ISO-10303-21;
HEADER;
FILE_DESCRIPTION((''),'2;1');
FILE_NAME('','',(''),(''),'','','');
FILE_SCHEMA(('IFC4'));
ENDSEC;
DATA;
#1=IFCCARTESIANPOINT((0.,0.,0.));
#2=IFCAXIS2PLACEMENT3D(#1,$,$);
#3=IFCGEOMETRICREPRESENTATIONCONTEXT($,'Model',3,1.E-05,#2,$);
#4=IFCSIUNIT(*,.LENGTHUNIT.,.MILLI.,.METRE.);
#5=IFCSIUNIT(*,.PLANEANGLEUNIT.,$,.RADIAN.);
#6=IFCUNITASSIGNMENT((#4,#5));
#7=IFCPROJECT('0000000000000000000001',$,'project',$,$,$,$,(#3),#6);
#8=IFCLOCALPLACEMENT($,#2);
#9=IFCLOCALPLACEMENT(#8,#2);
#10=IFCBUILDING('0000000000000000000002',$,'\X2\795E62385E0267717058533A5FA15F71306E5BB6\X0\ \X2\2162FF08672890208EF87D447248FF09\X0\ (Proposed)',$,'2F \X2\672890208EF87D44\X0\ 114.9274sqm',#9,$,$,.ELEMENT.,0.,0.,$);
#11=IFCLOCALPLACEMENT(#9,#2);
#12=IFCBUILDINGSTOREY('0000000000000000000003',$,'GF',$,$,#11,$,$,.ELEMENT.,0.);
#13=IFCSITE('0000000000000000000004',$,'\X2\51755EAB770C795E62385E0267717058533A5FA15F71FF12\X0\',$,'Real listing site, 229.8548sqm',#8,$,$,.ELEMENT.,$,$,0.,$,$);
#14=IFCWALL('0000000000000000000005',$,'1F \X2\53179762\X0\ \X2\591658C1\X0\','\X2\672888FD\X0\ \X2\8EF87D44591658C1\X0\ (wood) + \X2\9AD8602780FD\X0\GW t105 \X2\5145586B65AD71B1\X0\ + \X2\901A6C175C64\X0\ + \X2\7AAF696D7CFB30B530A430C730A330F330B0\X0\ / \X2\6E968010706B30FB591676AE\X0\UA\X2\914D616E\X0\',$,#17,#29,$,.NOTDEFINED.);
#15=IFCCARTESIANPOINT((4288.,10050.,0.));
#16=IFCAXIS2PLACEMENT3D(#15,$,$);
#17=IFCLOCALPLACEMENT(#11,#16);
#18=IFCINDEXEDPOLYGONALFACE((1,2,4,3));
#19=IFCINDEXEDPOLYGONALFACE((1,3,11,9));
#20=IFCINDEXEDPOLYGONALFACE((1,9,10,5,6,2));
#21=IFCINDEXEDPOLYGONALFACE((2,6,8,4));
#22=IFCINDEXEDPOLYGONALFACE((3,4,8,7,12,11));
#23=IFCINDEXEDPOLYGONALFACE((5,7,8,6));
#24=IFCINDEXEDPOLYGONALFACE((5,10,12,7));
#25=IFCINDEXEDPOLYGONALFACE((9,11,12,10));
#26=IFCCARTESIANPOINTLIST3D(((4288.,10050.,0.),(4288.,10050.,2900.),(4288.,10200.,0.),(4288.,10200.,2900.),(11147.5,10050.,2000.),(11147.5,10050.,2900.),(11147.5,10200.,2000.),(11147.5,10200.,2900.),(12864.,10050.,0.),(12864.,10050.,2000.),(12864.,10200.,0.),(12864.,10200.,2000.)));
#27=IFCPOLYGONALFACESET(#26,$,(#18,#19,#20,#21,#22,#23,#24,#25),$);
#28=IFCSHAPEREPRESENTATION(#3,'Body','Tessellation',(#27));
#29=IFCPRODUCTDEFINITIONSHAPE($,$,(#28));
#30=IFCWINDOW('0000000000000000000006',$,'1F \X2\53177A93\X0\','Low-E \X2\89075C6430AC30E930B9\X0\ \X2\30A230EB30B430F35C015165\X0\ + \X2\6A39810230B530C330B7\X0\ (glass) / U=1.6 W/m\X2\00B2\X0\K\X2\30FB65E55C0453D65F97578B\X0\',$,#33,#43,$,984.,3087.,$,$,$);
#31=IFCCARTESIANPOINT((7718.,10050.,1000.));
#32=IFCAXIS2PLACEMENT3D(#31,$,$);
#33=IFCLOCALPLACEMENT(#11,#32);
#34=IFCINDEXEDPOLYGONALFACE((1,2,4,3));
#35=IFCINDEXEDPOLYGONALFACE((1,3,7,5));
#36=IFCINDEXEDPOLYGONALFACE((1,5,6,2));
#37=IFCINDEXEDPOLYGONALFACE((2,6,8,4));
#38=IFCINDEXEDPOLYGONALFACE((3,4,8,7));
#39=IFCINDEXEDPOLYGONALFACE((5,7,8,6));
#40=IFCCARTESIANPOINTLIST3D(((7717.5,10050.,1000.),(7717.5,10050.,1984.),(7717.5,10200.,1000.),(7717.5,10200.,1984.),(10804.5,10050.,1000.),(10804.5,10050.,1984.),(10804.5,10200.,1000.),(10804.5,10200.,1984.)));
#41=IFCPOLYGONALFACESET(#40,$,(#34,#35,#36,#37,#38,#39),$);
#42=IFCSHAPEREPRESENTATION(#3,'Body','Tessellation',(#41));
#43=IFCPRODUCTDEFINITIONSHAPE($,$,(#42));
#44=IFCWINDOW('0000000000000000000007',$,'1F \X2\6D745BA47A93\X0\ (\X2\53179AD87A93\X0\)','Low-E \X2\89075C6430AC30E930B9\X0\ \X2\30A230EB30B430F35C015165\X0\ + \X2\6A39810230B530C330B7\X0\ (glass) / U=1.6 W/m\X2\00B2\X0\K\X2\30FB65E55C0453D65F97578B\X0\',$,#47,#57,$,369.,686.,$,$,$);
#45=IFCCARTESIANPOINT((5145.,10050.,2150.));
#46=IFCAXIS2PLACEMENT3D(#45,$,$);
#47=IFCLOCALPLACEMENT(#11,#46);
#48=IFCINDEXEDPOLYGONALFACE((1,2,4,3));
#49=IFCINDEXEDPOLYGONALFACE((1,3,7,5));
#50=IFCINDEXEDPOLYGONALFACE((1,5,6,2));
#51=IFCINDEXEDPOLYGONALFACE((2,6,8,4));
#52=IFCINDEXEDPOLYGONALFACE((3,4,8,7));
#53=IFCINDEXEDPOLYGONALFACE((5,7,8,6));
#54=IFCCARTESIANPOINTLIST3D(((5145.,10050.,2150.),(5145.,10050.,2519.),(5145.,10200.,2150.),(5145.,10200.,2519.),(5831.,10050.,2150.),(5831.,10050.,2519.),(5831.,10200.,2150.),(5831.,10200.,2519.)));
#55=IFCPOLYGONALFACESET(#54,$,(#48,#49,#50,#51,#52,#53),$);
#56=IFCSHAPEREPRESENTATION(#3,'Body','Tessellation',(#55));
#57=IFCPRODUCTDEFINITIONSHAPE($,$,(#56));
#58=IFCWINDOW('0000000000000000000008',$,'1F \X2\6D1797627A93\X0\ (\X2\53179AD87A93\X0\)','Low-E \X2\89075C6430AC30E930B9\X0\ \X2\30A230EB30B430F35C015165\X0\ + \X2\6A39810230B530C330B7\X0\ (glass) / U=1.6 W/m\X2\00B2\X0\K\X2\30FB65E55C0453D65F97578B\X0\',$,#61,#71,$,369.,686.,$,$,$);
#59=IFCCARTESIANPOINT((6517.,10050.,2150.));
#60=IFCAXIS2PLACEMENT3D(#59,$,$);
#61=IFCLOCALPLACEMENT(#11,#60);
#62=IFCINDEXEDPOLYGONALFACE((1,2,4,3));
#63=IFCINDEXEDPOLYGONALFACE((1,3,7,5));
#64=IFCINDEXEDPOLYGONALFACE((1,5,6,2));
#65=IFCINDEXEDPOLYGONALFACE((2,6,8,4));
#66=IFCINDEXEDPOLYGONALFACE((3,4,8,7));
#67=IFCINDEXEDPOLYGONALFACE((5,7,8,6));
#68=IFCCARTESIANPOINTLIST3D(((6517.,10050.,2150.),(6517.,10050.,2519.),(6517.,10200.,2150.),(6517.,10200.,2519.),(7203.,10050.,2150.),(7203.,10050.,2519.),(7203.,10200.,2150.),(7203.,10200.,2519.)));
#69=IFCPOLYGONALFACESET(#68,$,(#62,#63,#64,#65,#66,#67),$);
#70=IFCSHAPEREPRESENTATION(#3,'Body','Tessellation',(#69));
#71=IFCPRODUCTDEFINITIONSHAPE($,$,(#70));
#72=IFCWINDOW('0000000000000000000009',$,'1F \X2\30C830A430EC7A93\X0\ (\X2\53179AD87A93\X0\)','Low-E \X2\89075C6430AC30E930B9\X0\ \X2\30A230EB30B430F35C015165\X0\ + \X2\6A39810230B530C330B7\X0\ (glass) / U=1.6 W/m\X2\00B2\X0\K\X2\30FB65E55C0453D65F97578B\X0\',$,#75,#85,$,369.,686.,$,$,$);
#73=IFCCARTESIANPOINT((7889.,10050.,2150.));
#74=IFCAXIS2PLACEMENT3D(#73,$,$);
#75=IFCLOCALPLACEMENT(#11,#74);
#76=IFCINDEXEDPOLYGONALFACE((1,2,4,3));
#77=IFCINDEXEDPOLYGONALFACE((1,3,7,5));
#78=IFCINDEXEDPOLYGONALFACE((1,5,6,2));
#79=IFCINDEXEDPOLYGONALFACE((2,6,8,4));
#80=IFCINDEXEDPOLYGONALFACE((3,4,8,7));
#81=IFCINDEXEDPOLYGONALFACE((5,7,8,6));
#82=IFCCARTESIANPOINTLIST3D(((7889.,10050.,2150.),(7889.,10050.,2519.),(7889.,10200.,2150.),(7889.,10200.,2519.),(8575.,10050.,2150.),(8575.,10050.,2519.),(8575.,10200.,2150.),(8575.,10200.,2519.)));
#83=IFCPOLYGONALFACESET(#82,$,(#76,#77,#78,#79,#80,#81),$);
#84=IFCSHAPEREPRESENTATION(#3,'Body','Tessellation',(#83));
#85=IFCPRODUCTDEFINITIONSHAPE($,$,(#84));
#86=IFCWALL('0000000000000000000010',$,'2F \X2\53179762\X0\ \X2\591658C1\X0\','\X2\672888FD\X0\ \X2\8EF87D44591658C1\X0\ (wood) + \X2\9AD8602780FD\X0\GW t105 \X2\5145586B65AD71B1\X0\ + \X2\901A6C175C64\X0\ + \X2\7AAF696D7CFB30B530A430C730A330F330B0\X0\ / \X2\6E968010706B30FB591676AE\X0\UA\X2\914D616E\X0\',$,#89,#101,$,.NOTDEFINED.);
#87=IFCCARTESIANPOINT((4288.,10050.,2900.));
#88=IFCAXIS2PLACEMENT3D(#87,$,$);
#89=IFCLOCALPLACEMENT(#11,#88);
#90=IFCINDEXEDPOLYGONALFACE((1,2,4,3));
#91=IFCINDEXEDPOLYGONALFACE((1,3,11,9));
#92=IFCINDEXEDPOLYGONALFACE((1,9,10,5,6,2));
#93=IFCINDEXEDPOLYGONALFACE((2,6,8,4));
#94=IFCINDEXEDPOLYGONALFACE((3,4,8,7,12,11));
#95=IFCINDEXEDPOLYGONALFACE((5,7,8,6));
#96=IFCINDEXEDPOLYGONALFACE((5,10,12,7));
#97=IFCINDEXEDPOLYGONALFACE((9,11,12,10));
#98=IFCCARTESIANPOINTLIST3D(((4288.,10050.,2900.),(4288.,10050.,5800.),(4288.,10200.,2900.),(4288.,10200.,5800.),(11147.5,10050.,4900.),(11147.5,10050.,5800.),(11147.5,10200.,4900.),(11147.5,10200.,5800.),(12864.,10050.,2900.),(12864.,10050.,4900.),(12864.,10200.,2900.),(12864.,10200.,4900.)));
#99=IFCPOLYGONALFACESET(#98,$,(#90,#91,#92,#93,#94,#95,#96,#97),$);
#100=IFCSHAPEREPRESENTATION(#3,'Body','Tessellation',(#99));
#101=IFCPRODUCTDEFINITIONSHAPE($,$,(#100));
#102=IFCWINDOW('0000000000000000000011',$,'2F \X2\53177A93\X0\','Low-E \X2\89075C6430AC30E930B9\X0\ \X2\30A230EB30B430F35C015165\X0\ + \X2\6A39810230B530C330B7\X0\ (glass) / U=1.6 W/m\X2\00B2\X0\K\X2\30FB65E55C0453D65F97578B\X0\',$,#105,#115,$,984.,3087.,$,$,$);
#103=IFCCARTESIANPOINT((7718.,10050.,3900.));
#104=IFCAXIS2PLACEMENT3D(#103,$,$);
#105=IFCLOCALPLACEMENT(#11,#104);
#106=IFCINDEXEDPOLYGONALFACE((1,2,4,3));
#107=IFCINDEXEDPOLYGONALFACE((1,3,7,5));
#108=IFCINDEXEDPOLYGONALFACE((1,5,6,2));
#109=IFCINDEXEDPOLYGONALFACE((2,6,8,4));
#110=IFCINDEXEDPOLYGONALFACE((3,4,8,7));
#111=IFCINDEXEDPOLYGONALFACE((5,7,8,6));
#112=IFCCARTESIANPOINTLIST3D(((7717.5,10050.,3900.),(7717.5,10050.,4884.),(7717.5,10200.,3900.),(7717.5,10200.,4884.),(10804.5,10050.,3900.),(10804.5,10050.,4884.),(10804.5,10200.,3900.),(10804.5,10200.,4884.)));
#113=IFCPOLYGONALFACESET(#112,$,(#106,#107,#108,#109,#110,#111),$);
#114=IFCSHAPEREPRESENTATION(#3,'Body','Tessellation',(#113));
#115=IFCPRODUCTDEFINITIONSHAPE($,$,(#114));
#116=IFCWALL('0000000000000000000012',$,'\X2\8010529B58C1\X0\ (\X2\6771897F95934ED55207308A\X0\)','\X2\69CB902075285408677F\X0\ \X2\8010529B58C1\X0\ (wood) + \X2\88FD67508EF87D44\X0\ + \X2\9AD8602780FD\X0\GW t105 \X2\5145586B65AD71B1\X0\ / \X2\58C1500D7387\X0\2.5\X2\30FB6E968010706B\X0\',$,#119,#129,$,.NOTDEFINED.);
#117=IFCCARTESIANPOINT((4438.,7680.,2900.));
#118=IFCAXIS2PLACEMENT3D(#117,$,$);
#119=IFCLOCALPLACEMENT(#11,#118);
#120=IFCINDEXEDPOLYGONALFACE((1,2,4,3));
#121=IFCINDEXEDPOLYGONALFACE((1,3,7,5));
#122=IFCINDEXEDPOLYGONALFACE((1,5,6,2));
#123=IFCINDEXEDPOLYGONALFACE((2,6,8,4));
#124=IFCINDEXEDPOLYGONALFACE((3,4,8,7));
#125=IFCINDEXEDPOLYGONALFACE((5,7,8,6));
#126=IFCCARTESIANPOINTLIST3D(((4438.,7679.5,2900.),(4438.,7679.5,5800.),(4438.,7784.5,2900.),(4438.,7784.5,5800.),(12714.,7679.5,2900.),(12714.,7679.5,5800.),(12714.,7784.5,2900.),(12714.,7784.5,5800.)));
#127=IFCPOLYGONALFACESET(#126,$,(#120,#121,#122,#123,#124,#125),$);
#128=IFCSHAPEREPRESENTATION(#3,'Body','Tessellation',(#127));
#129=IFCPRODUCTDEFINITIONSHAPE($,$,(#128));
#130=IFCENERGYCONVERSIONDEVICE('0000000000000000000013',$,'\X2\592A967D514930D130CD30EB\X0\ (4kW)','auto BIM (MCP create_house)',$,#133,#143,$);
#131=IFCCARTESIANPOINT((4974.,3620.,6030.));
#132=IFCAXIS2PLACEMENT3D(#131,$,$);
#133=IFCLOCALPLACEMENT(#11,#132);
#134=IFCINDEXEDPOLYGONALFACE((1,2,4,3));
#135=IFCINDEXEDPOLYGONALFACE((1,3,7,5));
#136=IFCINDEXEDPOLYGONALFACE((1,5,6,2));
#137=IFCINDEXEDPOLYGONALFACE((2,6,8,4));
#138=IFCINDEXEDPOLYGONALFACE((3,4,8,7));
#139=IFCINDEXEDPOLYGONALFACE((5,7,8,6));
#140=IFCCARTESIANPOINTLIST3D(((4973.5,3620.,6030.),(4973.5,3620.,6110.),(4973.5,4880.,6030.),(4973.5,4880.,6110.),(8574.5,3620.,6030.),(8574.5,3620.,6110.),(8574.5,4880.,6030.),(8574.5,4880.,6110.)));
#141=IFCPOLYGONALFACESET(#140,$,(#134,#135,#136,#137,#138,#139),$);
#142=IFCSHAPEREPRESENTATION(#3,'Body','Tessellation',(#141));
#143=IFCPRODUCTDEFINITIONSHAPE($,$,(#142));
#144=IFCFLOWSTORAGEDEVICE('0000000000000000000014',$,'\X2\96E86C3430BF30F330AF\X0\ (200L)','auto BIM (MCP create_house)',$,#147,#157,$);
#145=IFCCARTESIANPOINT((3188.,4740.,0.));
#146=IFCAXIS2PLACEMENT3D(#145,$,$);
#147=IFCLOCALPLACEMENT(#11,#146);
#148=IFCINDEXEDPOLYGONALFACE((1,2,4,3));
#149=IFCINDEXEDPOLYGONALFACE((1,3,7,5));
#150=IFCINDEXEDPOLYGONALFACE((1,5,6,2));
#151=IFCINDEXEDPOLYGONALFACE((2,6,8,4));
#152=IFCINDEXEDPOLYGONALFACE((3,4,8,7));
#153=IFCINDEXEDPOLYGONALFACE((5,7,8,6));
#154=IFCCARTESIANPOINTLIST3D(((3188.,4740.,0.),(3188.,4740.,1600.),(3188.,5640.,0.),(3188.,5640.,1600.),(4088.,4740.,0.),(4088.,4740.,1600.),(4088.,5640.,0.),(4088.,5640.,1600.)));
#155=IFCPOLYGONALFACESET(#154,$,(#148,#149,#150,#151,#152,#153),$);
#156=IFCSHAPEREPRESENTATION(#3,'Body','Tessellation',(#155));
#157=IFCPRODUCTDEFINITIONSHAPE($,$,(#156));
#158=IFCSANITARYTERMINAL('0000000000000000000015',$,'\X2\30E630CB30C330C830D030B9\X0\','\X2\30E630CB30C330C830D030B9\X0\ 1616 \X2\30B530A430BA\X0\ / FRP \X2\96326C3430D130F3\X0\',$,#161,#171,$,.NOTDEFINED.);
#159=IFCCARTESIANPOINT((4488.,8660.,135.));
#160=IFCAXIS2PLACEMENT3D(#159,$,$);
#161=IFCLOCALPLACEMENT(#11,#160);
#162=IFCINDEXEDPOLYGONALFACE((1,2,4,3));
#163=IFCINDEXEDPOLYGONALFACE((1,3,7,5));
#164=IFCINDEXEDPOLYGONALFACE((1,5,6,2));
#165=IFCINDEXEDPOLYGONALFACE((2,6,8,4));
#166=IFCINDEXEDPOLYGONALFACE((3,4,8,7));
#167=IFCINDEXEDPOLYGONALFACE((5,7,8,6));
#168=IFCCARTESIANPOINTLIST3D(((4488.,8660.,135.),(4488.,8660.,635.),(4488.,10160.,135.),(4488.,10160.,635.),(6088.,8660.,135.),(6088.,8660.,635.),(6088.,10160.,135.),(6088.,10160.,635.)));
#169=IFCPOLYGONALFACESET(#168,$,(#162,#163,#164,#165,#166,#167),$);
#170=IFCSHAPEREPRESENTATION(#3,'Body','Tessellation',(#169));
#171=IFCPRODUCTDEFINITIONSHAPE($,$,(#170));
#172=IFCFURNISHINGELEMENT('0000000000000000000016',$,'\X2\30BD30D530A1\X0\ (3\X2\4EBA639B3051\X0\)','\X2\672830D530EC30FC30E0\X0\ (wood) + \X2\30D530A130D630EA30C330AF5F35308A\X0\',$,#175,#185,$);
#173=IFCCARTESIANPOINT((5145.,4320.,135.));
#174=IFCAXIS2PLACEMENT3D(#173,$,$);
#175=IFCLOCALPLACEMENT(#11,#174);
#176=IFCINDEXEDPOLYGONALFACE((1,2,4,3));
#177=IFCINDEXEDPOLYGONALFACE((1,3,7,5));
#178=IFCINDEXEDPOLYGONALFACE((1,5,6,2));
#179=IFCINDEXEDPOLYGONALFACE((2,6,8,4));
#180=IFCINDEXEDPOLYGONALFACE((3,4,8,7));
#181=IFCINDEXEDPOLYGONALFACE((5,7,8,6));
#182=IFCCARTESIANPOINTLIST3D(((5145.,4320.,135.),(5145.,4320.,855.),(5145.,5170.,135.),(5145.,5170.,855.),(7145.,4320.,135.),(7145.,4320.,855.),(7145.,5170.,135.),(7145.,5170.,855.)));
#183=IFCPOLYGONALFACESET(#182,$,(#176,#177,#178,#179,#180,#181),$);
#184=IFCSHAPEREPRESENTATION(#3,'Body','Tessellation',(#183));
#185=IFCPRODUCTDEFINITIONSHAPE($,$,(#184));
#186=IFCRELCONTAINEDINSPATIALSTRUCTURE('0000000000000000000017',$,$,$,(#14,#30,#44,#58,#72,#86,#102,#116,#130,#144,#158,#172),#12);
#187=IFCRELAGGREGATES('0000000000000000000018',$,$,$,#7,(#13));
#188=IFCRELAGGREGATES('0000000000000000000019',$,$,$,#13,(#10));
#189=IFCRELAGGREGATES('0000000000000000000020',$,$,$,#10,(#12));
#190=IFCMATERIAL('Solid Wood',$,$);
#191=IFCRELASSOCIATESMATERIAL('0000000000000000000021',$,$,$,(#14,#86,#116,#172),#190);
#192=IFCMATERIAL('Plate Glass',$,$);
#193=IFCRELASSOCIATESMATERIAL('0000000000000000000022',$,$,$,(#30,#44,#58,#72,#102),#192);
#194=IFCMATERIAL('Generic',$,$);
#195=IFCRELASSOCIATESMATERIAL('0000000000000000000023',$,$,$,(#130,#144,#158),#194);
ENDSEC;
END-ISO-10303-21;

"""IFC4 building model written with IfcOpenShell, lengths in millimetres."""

from ifc_helpers import new_model, si_unit, frame, frame_2d, origin, place, context, project, spatial, rectangle, extrude, material, element, fill, save


model = new_model("IFC4")

# Units and contexts
model_context = context("Model", 3, precision=1e-05, world=origin())
ifc_project = project(units=[si_unit("LENGTHUNIT", "METRE", prefix="MILLI"), si_unit("PLANEANGLEUNIT", "RADIAN")], contexts=[model_context])

# Site, building, storey
site_placement = place(None, origin())
site = spatial("IfcSite", under=ifc_project, at=site_placement, Name="兵庫県神戸市東灘区御影２", ObjectType="Real listing site, 229.8548sqm", CompositionType="ELEMENT", RefElevation=0.0)
building_placement = place(site_placement, origin())
building = spatial("IfcBuilding", under=site, at=building_placement, Name="神戸市東灘区御影の家 Ⅲ（木造軸組版） (Proposed)", ObjectType="2F 木造軸組 114.9274sqm", CompositionType="ELEMENT", ElevationOfRefHeight=0.0, ElevationOfTerrain=0.0)
storey_placement = place(building_placement, origin())
storey = spatial("IfcBuildingStorey", under=building, at=storey_placement, Name="GF", CompositionType="ELEMENT", Elevation=0.0)

# Wall, openings, windows
ifc_material_1 = material(Name="Solid Wood")
wall_1_placement = place(storey_placement, frame((4288.0, 10050.0, 0.0)))
wall_1 = element("IfcWall", 1, at=wall_1_placement, inside=storey, material=ifc_material_1, Name="1F 北面 外壁", Description="木製 軸組外壁 (wood) + 高性能GW t105 充填断熱 + 通気層 + 窯業系サイディング / 準耐火・外皮UA配慮", PredefinedType="NOTDEFINED", context=model_context, shape_type="SweptSolid", body=[
    extrude(rectangle(XDim=8576.0, YDim=150.0, at=frame_2d((4288.0, 75.0))), frame((4288.0, 10050.0, 0.0)), (0.0, 0.0, 1.0), 2900.0),
])
opening_1_placement = place(storey_placement, frame((7718.0, 10050.0, 1000.0)))
opening_1 = element("IfcOpeningElement", 2, at=opening_1_placement, cuts=wall_1, PredefinedType="NOTDEFINED", context=model_context, shape_type="SweptSolid", body=[
    extrude(rectangle(XDim=3087.0, YDim=150.0, at=frame_2d((1543.0, 75.0))), frame((7718.0, 10050.0, 1000.0)), (0.0, 0.0, 1.0), 984.0),
])
opening_2_placement = place(storey_placement, frame((5145.0, 10050.0, 2150.0)))
opening_2 = element("IfcOpeningElement", 3, at=opening_2_placement, cuts=wall_1, PredefinedType="NOTDEFINED", context=model_context, shape_type="SweptSolid", body=[
    extrude(rectangle(XDim=686.0, YDim=150.0, at=frame_2d((343.0, 75.0))), frame((5145.0, 10050.0, 2150.0)), (0.0, 0.0, 1.0), 369.0),
])
opening_3_placement = place(storey_placement, frame((6517.0, 10050.0, 2150.0)))
opening_3 = element("IfcOpeningElement", 4, at=opening_3_placement, cuts=wall_1, PredefinedType="NOTDEFINED", context=model_context, shape_type="SweptSolid", body=[
    extrude(rectangle(XDim=686.0, YDim=150.0, at=frame_2d((343.0, 75.0))), frame((6517.0, 10050.0, 2150.0)), (0.0, 0.0, 1.0), 369.0),
])
opening_4_placement = place(storey_placement, frame((7889.0, 10050.0, 2150.0)))
opening_4 = element("IfcOpeningElement", 5, at=opening_4_placement, cuts=wall_1, PredefinedType="NOTDEFINED", context=model_context, shape_type="SweptSolid", body=[
    extrude(rectangle(XDim=686.0, YDim=150.0, at=frame_2d((343.0, 75.0))), frame((7889.0, 10050.0, 2150.0)), (0.0, 0.0, 1.0), 369.0),
])
ifc_material_2 = material(Name="Plate Glass")
window_1_placement = place(storey_placement, frame((7718.0, 10050.0, 1000.0)))
window_1 = element("IfcWindow", 6, at=window_1_placement, inside=storey, material=ifc_material_2, Name="1F 北窓", Description="Low-E 複層ガラス アルゴン封入 + 樹脂サッシ (glass) / U=1.6 W/m²K・日射取得型", OverallHeight=984.0, OverallWidth=3087.0, context=model_context, shape_type="SweptSolid", body=[
    extrude(rectangle(XDim=3087.0, YDim=150.0, at=frame_2d((1543.0, 75.0))), frame((7718.0, 10050.0, 1000.0)), (0.0, 0.0, 1.0), 984.0),
])
fill(opening_1, window_1)
window_2_placement = place(storey_placement, frame((5145.0, 10050.0, 2150.0)))
window_2 = element("IfcWindow", 7, at=window_2_placement, inside=storey, material=ifc_material_2, Name="1F 浴室窓 (北高窓)", Description="Low-E 複層ガラス アルゴン封入 + 樹脂サッシ (glass) / U=1.6 W/m²K・日射取得型", OverallHeight=369.0, OverallWidth=686.0, context=model_context, shape_type="SweptSolid", body=[
    extrude(rectangle(XDim=686.0, YDim=150.0, at=frame_2d((343.0, 75.0))), frame((5145.0, 10050.0, 2150.0)), (0.0, 0.0, 1.0), 369.0),
])
fill(opening_2, window_2)
window_3_placement = place(storey_placement, frame((6517.0, 10050.0, 2150.0)))
window_3 = element("IfcWindow", 8, at=window_3_placement, inside=storey, material=ifc_material_2, Name="1F 洗面窓 (北高窓)", Description="Low-E 複層ガラス アルゴン封入 + 樹脂サッシ (glass) / U=1.6 W/m²K・日射取得型", OverallHeight=369.0, OverallWidth=686.0, context=model_context, shape_type="SweptSolid", body=[
    extrude(rectangle(XDim=686.0, YDim=150.0, at=frame_2d((343.0, 75.0))), frame((6517.0, 10050.0, 2150.0)), (0.0, 0.0, 1.0), 369.0),
])
fill(opening_3, window_3)
window_4_placement = place(storey_placement, frame((7889.0, 10050.0, 2150.0)))
window_4 = element("IfcWindow", 9, at=window_4_placement, inside=storey, material=ifc_material_2, Name="1F トイレ窓 (北高窓)", Description="Low-E 複層ガラス アルゴン封入 + 樹脂サッシ (glass) / U=1.6 W/m²K・日射取得型", OverallHeight=369.0, OverallWidth=686.0, context=model_context, shape_type="SweptSolid", body=[
    extrude(rectangle(XDim=686.0, YDim=150.0, at=frame_2d((343.0, 75.0))), frame((7889.0, 10050.0, 2150.0)), (0.0, 0.0, 1.0), 369.0),
])
fill(opening_4, window_4)

# Wall, opening, window
wall_2_placement = place(storey_placement, frame((4288.0, 10050.0, 2900.0)))
wall_2 = element("IfcWall", 10, at=wall_2_placement, inside=storey, material=ifc_material_1, Name="2F 北面 外壁", Description="木製 軸組外壁 (wood) + 高性能GW t105 充填断熱 + 通気層 + 窯業系サイディング / 準耐火・外皮UA配慮", PredefinedType="NOTDEFINED", context=model_context, shape_type="SweptSolid", body=[
    extrude(rectangle(XDim=8576.0, YDim=150.0, at=frame_2d((4288.0, 75.0))), frame((4288.0, 10050.0, 2900.0)), (0.0, 0.0, 1.0), 2900.0),
])
opening_5_placement = place(storey_placement, frame((7718.0, 10050.0, 3900.0)))
opening_5 = element("IfcOpeningElement", 11, at=opening_5_placement, cuts=wall_2, PredefinedType="NOTDEFINED", context=model_context, shape_type="SweptSolid", body=[
    extrude(rectangle(XDim=3087.0, YDim=150.0, at=frame_2d((1543.0, 75.0))), frame((7718.0, 10050.0, 3900.0)), (0.0, 0.0, 1.0), 984.0),
])
window_5_placement = place(storey_placement, frame((7718.0, 10050.0, 3900.0)))
window_5 = element("IfcWindow", 12, at=window_5_placement, inside=storey, material=ifc_material_2, Name="2F 北窓", Description="Low-E 複層ガラス アルゴン封入 + 樹脂サッシ (glass) / U=1.6 W/m²K・日射取得型", OverallHeight=984.0, OverallWidth=3087.0, context=model_context, shape_type="SweptSolid", body=[
    extrude(rectangle(XDim=3087.0, YDim=150.0, at=frame_2d((1543.0, 75.0))), frame((7718.0, 10050.0, 3900.0)), (0.0, 0.0, 1.0), 984.0),
])
fill(opening_5, window_5)

# Wall
wall_3_placement = place(storey_placement, frame((4438.0, 7680.0, 2900.0)))
element("IfcWall", 13, at=wall_3_placement, inside=storey, material=ifc_material_1, Name="耐力壁 (東西間仕切り)", Description="構造用合板 耐力壁 (wood) + 製材軸組 + 高性能GW t105 充填断熱 / 壁倍率2.5・準耐火", PredefinedType="NOTDEFINED", context=model_context, shape_type="SweptSolid", body=[
    extrude(rectangle(XDim=8276.0, YDim=105.0, at=frame_2d((4138.0, 52.0))), frame((4438.0, 7680.0, 2900.0)), (0.0, 0.0, 1.0), 2900.0),
])

# Energy conversion device
ifc_material_3 = material(Name="Generic")
energy_conversion_device_placement = place(storey_placement, frame((4974.0, 3620.0, 6030.0)))
element("IfcEnergyConversionDevice", 14, at=energy_conversion_device_placement, inside=storey, material=ifc_material_3, Name="太陽光パネル (4kW)", Description="auto BIM (MCP create_house)", context=model_context, shape_type="SweptSolid", body=[
    extrude(rectangle(XDim=3601.0, YDim=1260.0, at=frame_2d((1800.0, 630.0))), frame((4974.0, 3620.0, 6030.0)), (0.0, 0.0, 1.0), 80.0),
])

# Flow storage device
flow_storage_device_placement = place(storey_placement, frame((3188.0, 4740.0, 0.0)))
element("IfcFlowStorageDevice", 15, at=flow_storage_device_placement, inside=storey, material=ifc_material_3, Name="雨水タンク (200L)", Description="auto BIM (MCP create_house)", context=model_context, shape_type="SweptSolid", body=[
    extrude(rectangle(XDim=900.0, YDim=900.0, at=frame_2d((450.0, 450.0))), frame((3188.0, 4740.0, 0.0)), (0.0, 0.0, 1.0), 1600.0),
])

# Sanitary terminal
sanitary_terminal_placement = place(storey_placement, frame((4488.0, 8660.0, 135.0)))
element("IfcSanitaryTerminal", 16, at=sanitary_terminal_placement, inside=storey, material=ifc_material_3, Name="ユニットバス", Description="ユニットバス 1616 サイズ / FRP 防水パン", PredefinedType="NOTDEFINED", context=model_context, shape_type="SweptSolid", body=[
    extrude(rectangle(XDim=1600.0, YDim=1500.0, at=frame_2d((800.0, 750.0))), frame((4488.0, 8660.0, 135.0)), (0.0, 0.0, 1.0), 500.0),
])

# Furnishing element
furnishing_1_placement = place(storey_placement, frame((5145.0, 4320.0, 135.0)))
element("IfcFurnishingElement", 17, at=furnishing_1_placement, inside=storey, material=ifc_material_1, Name="ソファ (3人掛け)", Description="木フレーム (wood) + ファブリック張り", context=model_context, shape_type="SweptSolid", body=[
    extrude(rectangle(XDim=2000.0, YDim=850.0, at=frame_2d((1000.0, 425.0))), frame((5145.0, 4320.0, 135.0)), (0.0, 0.0, 1.0), 720.0),
])

save(model, "model.ifc")
